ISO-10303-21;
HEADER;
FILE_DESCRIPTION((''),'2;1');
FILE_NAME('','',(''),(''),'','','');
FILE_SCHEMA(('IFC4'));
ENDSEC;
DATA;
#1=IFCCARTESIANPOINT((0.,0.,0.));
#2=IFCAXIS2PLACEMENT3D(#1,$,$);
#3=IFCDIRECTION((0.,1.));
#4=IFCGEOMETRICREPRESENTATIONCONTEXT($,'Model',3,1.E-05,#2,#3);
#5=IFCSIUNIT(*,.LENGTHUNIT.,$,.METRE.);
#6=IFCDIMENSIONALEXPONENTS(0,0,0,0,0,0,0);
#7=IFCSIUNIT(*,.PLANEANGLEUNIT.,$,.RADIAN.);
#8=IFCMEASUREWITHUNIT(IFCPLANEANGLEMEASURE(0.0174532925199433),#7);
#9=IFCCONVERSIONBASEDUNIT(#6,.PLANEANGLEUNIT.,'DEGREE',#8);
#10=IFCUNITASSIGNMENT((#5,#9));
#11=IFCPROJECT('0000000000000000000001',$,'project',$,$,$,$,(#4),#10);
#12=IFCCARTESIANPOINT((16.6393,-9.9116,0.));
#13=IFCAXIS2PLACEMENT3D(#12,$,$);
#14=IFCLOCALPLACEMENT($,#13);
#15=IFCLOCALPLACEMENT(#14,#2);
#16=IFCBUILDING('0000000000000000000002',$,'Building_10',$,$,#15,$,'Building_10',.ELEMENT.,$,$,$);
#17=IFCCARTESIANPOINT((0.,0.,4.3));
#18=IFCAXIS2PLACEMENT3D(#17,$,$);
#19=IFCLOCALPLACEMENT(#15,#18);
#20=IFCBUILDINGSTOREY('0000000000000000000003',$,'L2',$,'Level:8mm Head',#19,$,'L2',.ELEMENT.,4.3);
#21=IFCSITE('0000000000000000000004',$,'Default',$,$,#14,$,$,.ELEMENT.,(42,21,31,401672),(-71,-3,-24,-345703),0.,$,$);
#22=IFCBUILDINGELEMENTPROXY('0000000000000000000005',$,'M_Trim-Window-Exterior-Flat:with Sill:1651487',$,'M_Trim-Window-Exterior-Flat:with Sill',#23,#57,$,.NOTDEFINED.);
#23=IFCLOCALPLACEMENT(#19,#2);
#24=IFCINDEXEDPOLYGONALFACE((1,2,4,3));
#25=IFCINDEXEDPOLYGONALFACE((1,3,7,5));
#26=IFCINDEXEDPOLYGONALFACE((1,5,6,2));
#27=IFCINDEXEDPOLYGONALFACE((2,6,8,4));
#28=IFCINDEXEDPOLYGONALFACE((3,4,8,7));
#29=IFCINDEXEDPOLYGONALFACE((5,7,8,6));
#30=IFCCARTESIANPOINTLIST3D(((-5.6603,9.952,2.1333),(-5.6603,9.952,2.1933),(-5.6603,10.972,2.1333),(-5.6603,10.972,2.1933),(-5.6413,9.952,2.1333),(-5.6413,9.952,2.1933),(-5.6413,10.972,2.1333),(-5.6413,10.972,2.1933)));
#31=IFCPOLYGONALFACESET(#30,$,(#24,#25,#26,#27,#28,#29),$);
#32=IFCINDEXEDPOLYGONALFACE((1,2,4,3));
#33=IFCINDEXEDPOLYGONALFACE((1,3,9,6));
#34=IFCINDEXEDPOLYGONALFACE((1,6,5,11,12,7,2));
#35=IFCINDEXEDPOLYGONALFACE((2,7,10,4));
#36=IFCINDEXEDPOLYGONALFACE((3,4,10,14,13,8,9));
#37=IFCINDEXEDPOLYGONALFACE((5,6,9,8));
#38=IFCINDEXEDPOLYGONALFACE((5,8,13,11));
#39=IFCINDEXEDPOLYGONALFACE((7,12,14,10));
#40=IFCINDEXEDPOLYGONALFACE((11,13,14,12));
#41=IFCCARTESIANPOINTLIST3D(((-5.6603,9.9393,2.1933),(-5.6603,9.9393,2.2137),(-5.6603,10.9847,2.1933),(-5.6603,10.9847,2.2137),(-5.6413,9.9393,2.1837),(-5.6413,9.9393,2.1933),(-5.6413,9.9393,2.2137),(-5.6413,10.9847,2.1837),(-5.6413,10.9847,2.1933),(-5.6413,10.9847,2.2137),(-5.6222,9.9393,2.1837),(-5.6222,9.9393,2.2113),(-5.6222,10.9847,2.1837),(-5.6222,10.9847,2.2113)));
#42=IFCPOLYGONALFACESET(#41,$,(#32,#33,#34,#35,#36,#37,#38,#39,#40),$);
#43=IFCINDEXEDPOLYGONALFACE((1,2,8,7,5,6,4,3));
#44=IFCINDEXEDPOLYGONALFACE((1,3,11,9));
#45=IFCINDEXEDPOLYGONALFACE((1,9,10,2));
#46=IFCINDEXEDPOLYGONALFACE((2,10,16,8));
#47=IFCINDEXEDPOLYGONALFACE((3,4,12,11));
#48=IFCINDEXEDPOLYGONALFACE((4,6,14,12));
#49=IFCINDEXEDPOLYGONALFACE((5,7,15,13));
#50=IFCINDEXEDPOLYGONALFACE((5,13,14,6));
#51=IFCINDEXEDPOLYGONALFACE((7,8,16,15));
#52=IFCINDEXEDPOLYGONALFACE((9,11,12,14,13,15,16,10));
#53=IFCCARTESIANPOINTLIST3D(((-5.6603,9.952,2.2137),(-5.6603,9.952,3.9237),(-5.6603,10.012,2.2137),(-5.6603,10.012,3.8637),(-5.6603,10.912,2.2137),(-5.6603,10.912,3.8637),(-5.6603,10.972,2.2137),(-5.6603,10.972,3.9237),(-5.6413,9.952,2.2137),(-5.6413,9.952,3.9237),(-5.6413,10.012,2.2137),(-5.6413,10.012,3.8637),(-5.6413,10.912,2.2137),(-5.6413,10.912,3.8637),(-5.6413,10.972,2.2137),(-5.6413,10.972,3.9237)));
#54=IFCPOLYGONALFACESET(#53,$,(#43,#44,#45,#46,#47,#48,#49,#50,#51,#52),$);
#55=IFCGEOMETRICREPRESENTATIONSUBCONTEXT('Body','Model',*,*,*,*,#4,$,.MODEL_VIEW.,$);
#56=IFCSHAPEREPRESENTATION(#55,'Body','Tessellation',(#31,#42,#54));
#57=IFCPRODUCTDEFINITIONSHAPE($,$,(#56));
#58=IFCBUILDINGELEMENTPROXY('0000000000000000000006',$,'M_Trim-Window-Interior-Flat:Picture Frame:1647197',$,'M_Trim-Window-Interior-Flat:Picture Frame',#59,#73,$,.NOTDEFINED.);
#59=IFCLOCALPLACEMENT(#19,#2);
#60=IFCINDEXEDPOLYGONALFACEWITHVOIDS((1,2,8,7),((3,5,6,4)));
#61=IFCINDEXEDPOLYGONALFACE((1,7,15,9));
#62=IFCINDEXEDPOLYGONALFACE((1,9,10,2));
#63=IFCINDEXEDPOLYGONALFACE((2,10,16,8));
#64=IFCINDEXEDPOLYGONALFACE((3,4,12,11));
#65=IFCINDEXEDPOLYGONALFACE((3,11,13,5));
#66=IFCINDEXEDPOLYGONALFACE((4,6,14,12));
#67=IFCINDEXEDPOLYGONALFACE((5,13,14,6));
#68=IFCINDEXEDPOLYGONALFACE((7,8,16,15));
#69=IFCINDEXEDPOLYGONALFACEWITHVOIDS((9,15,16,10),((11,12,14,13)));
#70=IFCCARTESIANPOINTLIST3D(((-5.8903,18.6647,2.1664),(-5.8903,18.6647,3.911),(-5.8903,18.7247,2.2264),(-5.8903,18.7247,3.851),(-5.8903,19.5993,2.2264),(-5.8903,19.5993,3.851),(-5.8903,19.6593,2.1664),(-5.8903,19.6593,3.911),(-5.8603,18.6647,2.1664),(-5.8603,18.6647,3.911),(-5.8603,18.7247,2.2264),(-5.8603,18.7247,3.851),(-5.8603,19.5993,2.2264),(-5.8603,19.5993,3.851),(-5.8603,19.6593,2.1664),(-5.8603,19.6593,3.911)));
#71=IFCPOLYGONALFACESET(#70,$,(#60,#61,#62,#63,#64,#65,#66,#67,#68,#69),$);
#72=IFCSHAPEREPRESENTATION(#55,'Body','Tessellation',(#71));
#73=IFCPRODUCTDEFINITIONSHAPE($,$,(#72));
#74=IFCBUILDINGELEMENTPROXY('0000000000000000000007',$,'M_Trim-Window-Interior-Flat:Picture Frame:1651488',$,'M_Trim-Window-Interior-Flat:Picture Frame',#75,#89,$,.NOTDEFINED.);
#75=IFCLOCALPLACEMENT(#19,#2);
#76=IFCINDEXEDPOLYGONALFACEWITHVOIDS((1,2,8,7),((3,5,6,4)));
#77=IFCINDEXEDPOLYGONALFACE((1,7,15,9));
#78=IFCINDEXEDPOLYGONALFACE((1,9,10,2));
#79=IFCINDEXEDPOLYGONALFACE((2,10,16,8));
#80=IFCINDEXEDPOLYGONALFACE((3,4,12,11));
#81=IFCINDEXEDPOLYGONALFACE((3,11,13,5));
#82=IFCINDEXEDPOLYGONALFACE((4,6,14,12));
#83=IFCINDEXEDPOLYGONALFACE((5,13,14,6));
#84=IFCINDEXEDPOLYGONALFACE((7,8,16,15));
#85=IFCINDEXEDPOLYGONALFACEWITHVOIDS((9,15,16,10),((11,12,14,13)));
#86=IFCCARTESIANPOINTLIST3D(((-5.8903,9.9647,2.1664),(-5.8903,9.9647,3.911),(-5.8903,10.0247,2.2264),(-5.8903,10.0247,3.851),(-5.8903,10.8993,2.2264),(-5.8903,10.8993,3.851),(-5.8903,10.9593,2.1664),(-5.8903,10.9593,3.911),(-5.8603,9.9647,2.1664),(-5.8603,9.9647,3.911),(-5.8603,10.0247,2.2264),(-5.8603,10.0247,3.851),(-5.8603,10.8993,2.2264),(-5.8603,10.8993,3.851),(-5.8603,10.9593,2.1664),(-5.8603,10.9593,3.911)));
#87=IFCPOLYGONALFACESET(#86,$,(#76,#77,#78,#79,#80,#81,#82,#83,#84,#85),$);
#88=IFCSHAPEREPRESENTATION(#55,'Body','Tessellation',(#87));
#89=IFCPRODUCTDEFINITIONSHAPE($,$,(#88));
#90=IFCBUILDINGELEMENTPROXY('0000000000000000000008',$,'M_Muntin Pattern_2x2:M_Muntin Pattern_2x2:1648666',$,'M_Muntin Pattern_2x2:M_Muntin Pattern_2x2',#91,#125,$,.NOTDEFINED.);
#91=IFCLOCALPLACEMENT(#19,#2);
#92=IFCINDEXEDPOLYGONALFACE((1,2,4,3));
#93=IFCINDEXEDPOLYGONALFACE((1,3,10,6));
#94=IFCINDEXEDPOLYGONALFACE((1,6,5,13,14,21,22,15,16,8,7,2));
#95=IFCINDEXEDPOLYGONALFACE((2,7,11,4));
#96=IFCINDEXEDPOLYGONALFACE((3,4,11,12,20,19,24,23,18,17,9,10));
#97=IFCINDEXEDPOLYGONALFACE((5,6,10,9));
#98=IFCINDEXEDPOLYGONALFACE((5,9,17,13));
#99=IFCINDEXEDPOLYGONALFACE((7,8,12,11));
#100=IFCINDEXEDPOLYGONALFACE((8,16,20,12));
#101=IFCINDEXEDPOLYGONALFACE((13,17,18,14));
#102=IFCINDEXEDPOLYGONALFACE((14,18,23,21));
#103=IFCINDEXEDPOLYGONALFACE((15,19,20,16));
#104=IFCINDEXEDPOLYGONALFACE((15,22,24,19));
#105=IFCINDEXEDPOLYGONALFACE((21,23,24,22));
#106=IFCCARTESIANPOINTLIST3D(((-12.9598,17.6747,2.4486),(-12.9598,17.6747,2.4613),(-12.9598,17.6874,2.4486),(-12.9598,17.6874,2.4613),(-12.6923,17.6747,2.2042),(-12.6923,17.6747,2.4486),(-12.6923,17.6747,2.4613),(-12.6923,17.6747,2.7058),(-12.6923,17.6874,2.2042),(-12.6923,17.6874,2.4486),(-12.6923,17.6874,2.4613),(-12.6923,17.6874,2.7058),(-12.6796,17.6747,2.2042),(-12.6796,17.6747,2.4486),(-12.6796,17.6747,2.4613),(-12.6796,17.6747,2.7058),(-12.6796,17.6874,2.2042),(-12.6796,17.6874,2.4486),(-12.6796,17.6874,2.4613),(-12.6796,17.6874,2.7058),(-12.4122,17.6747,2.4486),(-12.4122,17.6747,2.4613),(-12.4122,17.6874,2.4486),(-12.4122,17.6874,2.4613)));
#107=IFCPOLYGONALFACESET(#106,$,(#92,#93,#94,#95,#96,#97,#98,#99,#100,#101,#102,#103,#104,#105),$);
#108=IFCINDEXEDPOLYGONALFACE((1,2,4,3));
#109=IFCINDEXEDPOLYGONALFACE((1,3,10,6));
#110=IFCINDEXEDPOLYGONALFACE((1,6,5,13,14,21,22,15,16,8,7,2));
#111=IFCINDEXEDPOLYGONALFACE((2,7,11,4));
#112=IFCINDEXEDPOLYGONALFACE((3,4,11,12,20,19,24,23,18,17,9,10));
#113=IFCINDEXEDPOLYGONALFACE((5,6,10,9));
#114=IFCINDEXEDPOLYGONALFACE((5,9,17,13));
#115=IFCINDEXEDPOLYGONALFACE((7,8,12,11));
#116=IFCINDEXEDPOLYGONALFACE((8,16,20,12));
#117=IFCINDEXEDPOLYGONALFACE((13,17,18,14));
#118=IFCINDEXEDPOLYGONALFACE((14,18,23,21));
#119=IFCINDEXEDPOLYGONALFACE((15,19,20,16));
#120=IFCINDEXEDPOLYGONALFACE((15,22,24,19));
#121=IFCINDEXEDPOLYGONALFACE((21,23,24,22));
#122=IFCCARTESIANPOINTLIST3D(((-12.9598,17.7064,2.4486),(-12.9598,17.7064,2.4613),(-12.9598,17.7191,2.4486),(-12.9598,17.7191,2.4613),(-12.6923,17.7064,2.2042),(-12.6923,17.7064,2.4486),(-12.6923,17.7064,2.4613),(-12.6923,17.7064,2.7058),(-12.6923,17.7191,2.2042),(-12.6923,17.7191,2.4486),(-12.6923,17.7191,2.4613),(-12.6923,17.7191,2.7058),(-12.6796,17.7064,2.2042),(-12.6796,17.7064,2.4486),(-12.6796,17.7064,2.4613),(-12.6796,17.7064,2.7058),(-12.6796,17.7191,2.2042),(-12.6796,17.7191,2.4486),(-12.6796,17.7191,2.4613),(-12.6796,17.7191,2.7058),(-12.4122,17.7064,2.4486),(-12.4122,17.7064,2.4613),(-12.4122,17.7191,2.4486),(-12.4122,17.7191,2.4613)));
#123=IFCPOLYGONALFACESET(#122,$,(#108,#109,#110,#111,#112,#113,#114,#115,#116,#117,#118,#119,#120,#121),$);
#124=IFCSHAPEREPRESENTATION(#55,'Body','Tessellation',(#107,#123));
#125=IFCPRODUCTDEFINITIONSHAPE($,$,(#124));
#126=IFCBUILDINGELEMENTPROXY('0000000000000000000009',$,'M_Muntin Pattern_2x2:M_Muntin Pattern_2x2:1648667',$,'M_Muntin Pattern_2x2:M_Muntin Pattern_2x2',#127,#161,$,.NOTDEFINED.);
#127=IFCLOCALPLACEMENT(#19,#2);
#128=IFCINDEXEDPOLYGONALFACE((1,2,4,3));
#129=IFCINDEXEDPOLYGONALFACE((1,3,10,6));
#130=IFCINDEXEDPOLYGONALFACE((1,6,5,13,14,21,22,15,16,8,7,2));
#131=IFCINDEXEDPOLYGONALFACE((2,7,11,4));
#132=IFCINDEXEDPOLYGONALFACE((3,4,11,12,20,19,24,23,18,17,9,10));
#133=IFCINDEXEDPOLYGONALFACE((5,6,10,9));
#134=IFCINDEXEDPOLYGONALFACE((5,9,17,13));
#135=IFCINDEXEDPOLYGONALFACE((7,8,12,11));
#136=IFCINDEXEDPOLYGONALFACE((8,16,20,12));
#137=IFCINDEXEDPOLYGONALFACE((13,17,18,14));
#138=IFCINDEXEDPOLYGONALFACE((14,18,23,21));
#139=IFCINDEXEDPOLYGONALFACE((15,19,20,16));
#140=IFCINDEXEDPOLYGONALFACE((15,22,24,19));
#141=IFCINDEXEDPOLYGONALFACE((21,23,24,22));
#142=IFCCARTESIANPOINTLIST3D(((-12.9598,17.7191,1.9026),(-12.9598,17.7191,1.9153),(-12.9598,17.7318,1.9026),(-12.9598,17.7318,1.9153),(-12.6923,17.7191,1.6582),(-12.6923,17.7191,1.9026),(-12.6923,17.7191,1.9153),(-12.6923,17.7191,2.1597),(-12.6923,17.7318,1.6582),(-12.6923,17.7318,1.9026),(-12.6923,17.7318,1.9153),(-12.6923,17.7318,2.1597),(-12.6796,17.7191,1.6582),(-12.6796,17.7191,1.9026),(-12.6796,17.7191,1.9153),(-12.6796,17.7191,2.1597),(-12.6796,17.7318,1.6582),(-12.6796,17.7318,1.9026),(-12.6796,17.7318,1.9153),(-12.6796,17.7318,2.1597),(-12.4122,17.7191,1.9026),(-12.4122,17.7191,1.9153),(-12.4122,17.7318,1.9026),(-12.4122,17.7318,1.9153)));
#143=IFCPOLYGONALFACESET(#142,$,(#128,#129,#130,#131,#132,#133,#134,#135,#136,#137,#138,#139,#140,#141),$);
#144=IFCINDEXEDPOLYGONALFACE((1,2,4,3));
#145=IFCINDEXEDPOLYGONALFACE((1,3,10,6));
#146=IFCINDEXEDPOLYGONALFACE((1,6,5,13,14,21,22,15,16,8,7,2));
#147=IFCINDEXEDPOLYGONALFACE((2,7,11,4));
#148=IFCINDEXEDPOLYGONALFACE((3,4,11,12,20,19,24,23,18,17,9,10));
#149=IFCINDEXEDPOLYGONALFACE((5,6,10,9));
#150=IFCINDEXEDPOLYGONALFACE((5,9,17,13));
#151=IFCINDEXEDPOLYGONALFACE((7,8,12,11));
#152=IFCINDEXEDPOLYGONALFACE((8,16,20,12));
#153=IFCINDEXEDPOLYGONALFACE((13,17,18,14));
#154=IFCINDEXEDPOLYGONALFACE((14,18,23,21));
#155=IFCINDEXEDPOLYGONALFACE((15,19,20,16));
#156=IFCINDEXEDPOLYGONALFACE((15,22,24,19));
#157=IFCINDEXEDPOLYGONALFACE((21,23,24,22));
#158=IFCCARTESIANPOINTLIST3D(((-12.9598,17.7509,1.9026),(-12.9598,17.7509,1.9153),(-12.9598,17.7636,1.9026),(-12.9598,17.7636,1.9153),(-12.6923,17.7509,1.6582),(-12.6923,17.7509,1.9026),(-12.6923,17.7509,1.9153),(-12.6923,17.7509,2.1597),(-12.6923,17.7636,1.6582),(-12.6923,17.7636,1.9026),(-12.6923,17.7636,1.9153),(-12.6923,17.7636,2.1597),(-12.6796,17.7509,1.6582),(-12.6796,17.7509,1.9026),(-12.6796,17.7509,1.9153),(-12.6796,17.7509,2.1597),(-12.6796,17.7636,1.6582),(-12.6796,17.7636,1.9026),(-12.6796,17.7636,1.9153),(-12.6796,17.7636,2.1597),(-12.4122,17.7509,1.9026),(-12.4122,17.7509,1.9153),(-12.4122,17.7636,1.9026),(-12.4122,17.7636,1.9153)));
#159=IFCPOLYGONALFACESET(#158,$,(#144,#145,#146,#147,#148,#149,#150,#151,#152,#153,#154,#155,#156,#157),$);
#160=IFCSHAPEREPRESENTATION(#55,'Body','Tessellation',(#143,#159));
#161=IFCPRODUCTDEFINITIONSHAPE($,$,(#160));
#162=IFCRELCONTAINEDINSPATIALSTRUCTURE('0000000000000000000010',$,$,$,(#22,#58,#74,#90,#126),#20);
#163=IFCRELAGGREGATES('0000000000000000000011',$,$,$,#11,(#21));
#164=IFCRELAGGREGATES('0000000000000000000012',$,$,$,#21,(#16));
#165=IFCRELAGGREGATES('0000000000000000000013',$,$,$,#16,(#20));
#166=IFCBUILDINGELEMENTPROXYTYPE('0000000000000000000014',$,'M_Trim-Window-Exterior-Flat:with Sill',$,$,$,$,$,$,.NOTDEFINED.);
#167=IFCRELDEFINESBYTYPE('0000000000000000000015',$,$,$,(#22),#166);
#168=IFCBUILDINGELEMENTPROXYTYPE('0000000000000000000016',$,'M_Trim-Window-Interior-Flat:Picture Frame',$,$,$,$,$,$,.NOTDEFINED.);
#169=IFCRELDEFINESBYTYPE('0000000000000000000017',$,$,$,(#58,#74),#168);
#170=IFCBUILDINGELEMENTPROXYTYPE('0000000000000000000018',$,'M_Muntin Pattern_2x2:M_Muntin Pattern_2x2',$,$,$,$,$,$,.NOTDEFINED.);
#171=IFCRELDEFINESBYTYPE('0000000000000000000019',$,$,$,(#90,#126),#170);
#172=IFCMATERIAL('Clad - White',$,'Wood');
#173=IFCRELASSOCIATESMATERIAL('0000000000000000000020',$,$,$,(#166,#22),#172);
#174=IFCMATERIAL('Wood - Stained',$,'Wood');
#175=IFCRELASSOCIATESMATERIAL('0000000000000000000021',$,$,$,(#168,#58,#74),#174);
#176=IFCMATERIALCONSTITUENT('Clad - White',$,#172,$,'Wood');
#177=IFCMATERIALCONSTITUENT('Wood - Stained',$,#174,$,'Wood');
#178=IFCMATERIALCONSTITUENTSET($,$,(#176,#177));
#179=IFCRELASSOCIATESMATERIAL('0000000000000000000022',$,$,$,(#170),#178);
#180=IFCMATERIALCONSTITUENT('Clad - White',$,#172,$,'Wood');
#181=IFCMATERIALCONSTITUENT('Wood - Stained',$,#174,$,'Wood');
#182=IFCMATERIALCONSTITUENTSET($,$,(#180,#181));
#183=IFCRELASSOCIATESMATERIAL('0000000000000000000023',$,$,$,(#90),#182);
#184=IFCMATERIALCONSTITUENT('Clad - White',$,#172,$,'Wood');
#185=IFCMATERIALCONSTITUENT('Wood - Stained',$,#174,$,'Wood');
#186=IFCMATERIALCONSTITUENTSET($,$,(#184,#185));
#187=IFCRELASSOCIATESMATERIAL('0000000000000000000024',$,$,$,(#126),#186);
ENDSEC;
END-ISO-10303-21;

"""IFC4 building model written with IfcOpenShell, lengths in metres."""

from ifc_helpers import new_model, entity, si_unit, converted_unit, direction, frame, origin, place, context, subcontext, project, spatial, indexed_curve, outline, extrude, source, transform, mapped, material, constituent, constituent_set, type_object, type_shapes, element, save


model = new_model("IFC4")

# Units and contexts
model_context = context("Model", 3, precision=1e-05, world=origin(), true_north=direction((0.0, 1.0)))
body_context = subcontext(model_context, "Body", "Model", "MODEL_VIEW")
ifc_project = project(units=[si_unit("LENGTHUNIT", "METRE"), converted_unit("PLANEANGLEUNIT", "DEGREE", entity("IfcPlaneAngleMeasure", 0.0174532925199433), si_unit("PLANEANGLEUNIT", "RADIAN"), dimensions=[0, 0, 0, 0, 0, 0, 0])], contexts=[model_context])

# Site, building, storey
site_placement = place(None, frame((16.6393, -9.9116, 0.0)))
site = spatial("IfcSite", under=ifc_project, at=site_placement, Name="Default", CompositionType="ELEMENT", RefLatitude=(42, 21, 31, 401672), RefLongitude=(-71, -3, -24, -345703), RefElevation=0.0)
building_placement = place(site_placement, origin())
building = spatial("IfcBuilding", under=site, at=building_placement, Name="Building_10", LongName="Building_10", CompositionType="ELEMENT")
storey_placement = place(building_placement, frame((0.0, 0.0, 4.3)))
storey = spatial("IfcBuildingStorey", under=building, at=storey_placement, Name="L2", ObjectType="Level:8mm Head", LongName="L2", CompositionType="ELEMENT", Elevation=4.3)

# Building element proxies
ifc_material_1 = material(Name="Clad - White", Category="Wood")
ifc_material_2 = material(Name="Wood - Stained", Category="Wood")
building_element_proxy_type_1 = type_object("IfcBuildingElementProxyType", Name="M_Trim-Window-Exterior-Flat:with Sill", PredefinedType="NOTDEFINED", material=ifc_material_1)
shared_shape_1 = source(origin(), body_context, "Body", "SweptSolid", [
    extrude(outline(indexed_curve([(-0.51, -0.03), (0.51, -0.03), (0.51, 0.03), (-0.51, 0.03), (-0.51, -0.03)], self_intersect=False)), frame((0.0, -1.7004, 0.0), z_axis=(0.0, 0.0, 1.0), x_axis=(-1.0, 0.0, 0.0)), (0.0, 0.0, 1.0), 0.0191),
    extrude(outline(indexed_curve([(-0.019, -0.0152), (0.0, -0.0152), (0.0, -0.0057), (0.019, -0.0057), (0.019, 0.0148), (0.0, 0.0148), (-0.019, 0.0123), (-0.019, -0.0152)], self_intersect=False)), frame((-0.5227, -1.6648, 0.019), z_axis=(1.0, 0.0, 0.0), x_axis=(0.0, 0.0, -1.0)), (0.0, 0.0, 1.0), 1.0454),
    extrude(outline(indexed_curve([(-0.87, -0.51), (0.84, -0.51), (0.84, -0.45), (-0.81, -0.45), (-0.81, 0.45), (0.84, 0.45), (0.84, 0.51), (-0.87, 0.51), (-0.87, -0.51)], self_intersect=False)), frame((0.0, -0.81, 0.0), z_axis=(0.0, 0.0, 1.0), x_axis=(0.0, -1.0, 0.0)), (0.0, 0.0, 1.0), 0.0191),
])
type_shapes(building_element_proxy_type_1, [shared_shape_1])
for number, where, z_axis, x_axis, name in (
    (1, (-5.6603, 10.462, 3.8637), (1.0, 0.0, 0.0), (0.0, 1.0, 0.0), "M_Trim-Window-Exterior-Flat:with Sill:1651487"),
):
    element("IfcBuildingElementProxy", number, at=place(storey_placement, frame(where, z_axis=z_axis, x_axis=x_axis)), inside=storey, type_object=building_element_proxy_type_1, material=ifc_material_1, Name=name, ObjectType="M_Trim-Window-Exterior-Flat:with Sill", PredefinedType="NOTDEFINED", context=body_context, shape_type="MappedRepresentation", body=[
        mapped(shared_shape_1, transform((0.0, 0.0, 0.0), scale=1.0)),
    ])
building_element_proxy_type_2 = type_object("IfcBuildingElementProxyType", Name="M_Trim-Window-Interior-Flat:Picture Frame", PredefinedType="NOTDEFINED", material=ifc_material_2)
shared_shape_2 = source(origin(), body_context, "Body", "SweptSolid", [
    extrude(outline(indexed_curve([(-0.4973, -0.8723), (0.4973, -0.8723), (0.4973, 0.8723), (-0.4973, 0.8723), (-0.4973, -0.8723)], self_intersect=False), holes=[indexed_curve([(-0.4373, -0.8123), (-0.4373, 0.8123), (0.4373, 0.8123), (0.4373, -0.8123), (-0.4373, -0.8123)], self_intersect=False)]), frame((0.0, -0.825, 0.0), z_axis=(0.0, 0.0, 1.0), x_axis=(-1.0, 0.0, 0.0)), (0.0, 0.0, 1.0), 0.03),
])
type_shapes(building_element_proxy_type_2, [shared_shape_2])
for number, where, z_axis, x_axis, name in (
    (2, (-5.8603, 19.162, 3.8637), (-1.0, 0.0, 0.0), (0.0, -1.0, 0.0), "M_Trim-Window-Interior-Flat:Picture Frame:1647197"),
    (3, (-5.8603, 10.462, 3.8637), (-1.0, 0.0, 0.0), (0.0, -1.0, 0.0), "M_Trim-Window-Interior-Flat:Picture Frame:1651488"),
):
    element("IfcBuildingElementProxy", number, at=place(storey_placement, frame(where, z_axis=z_axis, x_axis=x_axis)), inside=storey, type_object=building_element_proxy_type_2, material=ifc_material_2, Name=name, ObjectType="M_Trim-Window-Interior-Flat:Picture Frame", PredefinedType="NOTDEFINED", context=body_context, shape_type="MappedRepresentation", body=[
        mapped(shared_shape_2, transform((0.0, 0.0, 0.0), scale=1.0)),
    ])
ifc_constituent_1 = constituent(ifc_material_1, Name="Clad - White", Category="Wood")
ifc_constituent_2 = constituent(ifc_material_2, Name="Wood - Stained", Category="Wood")
ifc_constituent_set_1 = constituent_set(constituents=[ifc_constituent_1, ifc_constituent_2])
ifc_constituent_3 = constituent(ifc_material_1, Name="Clad - White", Category="Wood")
ifc_constituent_4 = constituent(ifc_material_2, Name="Wood - Stained", Category="Wood")
ifc_constituent_set_2 = constituent_set(constituents=[ifc_constituent_3, ifc_constituent_4])
building_element_proxy_type_3 = type_object("IfcBuildingElementProxyType", Name="M_Muntin Pattern_2x2:M_Muntin Pattern_2x2", PredefinedType="NOTDEFINED", material=ifc_constituent_set_2)
shared_shape_3 = source(origin(), body_context, "Body", "SweptSolid", [
    extrude(outline(indexed_curve([(0.0064, -0.0064), (0.2508, -0.0064), (0.2508, 0.0063), (0.0064, 0.0063), (0.0064, 0.2738), (-0.0063, 0.2738), (-0.0063, 0.0063), (-0.2508, 0.0063), (-0.2508, -0.0064), (-0.0063, -0.0064), (-0.0063, -0.2738), (0.0064, -0.2738), (0.0064, -0.0064)], self_intersect=False)), frame((0.0, 0.0095, 0.2508), z_axis=(0.0, 1.0, 0.0), x_axis=(0.0, 0.0, 1.0)), (0.0, 0.0, 1.0), 0.0127),
    extrude(outline(indexed_curve([(0.0064, -0.0064), (0.2508, -0.0064), (0.2508, 0.0063), (0.0064, 0.0063), (0.0064, 0.2738), (-0.0063, 0.2738), (-0.0063, 0.0063), (-0.2508, 0.0063), (-0.2508, -0.0064), (-0.0063, -0.0064), (-0.0063, -0.2738), (0.0064, -0.2738), (0.0064, -0.0064)], self_intersect=False)), frame((0.0, -0.0222, 0.2508), z_axis=(0.0, 1.0, 0.0), x_axis=(0.0, 0.0, 1.0)), (0.0, 0.0, 1.0), 0.0127),
])
type_shapes(building_element_proxy_type_3, [shared_shape_3])
proxy_1_placement = place(storey_placement, frame((-12.686, 17.6969, 2.2042), z_axis=(0.0, 0.0, 1.0), x_axis=(-1.0, 0.0, 0.0)))
element("IfcBuildingElementProxy", 4, at=proxy_1_placement, inside=storey, type_object=building_element_proxy_type_3, material=ifc_constituent_set_1, Name="M_Muntin Pattern_2x2:M_Muntin Pattern_2x2:1648666", ObjectType="M_Muntin Pattern_2x2:M_Muntin Pattern_2x2", PredefinedType="NOTDEFINED", context=body_context, shape_type="MappedRepresentation", body=[
    mapped(shared_shape_3, transform((0.0, 0.0, 0.0), scale=1.0)),
])
ifc_constituent_5 = constituent(ifc_material_1, Name="Clad - White", Category="Wood")
ifc_constituent_6 = constituent(ifc_material_2, Name="Wood - Stained", Category="Wood")
ifc_constituent_set_3 = constituent_set(constituents=[ifc_constituent_5, ifc_constituent_6])
proxy_2_placement = place(storey_placement, frame((-12.686, 17.7413, 1.6582), z_axis=(0.0, 0.0, 1.0), x_axis=(-1.0, 0.0, 0.0)))
element("IfcBuildingElementProxy", 5, at=proxy_2_placement, inside=storey, type_object=building_element_proxy_type_3, material=ifc_constituent_set_3, Name="M_Muntin Pattern_2x2:M_Muntin Pattern_2x2:1648667", ObjectType="M_Muntin Pattern_2x2:M_Muntin Pattern_2x2", PredefinedType="NOTDEFINED", context=body_context, shape_type="MappedRepresentation", body=[
    mapped(shared_shape_3, transform((0.0, 0.0, 0.0), scale=1.0)),
])

save(model, "model.ifc")
